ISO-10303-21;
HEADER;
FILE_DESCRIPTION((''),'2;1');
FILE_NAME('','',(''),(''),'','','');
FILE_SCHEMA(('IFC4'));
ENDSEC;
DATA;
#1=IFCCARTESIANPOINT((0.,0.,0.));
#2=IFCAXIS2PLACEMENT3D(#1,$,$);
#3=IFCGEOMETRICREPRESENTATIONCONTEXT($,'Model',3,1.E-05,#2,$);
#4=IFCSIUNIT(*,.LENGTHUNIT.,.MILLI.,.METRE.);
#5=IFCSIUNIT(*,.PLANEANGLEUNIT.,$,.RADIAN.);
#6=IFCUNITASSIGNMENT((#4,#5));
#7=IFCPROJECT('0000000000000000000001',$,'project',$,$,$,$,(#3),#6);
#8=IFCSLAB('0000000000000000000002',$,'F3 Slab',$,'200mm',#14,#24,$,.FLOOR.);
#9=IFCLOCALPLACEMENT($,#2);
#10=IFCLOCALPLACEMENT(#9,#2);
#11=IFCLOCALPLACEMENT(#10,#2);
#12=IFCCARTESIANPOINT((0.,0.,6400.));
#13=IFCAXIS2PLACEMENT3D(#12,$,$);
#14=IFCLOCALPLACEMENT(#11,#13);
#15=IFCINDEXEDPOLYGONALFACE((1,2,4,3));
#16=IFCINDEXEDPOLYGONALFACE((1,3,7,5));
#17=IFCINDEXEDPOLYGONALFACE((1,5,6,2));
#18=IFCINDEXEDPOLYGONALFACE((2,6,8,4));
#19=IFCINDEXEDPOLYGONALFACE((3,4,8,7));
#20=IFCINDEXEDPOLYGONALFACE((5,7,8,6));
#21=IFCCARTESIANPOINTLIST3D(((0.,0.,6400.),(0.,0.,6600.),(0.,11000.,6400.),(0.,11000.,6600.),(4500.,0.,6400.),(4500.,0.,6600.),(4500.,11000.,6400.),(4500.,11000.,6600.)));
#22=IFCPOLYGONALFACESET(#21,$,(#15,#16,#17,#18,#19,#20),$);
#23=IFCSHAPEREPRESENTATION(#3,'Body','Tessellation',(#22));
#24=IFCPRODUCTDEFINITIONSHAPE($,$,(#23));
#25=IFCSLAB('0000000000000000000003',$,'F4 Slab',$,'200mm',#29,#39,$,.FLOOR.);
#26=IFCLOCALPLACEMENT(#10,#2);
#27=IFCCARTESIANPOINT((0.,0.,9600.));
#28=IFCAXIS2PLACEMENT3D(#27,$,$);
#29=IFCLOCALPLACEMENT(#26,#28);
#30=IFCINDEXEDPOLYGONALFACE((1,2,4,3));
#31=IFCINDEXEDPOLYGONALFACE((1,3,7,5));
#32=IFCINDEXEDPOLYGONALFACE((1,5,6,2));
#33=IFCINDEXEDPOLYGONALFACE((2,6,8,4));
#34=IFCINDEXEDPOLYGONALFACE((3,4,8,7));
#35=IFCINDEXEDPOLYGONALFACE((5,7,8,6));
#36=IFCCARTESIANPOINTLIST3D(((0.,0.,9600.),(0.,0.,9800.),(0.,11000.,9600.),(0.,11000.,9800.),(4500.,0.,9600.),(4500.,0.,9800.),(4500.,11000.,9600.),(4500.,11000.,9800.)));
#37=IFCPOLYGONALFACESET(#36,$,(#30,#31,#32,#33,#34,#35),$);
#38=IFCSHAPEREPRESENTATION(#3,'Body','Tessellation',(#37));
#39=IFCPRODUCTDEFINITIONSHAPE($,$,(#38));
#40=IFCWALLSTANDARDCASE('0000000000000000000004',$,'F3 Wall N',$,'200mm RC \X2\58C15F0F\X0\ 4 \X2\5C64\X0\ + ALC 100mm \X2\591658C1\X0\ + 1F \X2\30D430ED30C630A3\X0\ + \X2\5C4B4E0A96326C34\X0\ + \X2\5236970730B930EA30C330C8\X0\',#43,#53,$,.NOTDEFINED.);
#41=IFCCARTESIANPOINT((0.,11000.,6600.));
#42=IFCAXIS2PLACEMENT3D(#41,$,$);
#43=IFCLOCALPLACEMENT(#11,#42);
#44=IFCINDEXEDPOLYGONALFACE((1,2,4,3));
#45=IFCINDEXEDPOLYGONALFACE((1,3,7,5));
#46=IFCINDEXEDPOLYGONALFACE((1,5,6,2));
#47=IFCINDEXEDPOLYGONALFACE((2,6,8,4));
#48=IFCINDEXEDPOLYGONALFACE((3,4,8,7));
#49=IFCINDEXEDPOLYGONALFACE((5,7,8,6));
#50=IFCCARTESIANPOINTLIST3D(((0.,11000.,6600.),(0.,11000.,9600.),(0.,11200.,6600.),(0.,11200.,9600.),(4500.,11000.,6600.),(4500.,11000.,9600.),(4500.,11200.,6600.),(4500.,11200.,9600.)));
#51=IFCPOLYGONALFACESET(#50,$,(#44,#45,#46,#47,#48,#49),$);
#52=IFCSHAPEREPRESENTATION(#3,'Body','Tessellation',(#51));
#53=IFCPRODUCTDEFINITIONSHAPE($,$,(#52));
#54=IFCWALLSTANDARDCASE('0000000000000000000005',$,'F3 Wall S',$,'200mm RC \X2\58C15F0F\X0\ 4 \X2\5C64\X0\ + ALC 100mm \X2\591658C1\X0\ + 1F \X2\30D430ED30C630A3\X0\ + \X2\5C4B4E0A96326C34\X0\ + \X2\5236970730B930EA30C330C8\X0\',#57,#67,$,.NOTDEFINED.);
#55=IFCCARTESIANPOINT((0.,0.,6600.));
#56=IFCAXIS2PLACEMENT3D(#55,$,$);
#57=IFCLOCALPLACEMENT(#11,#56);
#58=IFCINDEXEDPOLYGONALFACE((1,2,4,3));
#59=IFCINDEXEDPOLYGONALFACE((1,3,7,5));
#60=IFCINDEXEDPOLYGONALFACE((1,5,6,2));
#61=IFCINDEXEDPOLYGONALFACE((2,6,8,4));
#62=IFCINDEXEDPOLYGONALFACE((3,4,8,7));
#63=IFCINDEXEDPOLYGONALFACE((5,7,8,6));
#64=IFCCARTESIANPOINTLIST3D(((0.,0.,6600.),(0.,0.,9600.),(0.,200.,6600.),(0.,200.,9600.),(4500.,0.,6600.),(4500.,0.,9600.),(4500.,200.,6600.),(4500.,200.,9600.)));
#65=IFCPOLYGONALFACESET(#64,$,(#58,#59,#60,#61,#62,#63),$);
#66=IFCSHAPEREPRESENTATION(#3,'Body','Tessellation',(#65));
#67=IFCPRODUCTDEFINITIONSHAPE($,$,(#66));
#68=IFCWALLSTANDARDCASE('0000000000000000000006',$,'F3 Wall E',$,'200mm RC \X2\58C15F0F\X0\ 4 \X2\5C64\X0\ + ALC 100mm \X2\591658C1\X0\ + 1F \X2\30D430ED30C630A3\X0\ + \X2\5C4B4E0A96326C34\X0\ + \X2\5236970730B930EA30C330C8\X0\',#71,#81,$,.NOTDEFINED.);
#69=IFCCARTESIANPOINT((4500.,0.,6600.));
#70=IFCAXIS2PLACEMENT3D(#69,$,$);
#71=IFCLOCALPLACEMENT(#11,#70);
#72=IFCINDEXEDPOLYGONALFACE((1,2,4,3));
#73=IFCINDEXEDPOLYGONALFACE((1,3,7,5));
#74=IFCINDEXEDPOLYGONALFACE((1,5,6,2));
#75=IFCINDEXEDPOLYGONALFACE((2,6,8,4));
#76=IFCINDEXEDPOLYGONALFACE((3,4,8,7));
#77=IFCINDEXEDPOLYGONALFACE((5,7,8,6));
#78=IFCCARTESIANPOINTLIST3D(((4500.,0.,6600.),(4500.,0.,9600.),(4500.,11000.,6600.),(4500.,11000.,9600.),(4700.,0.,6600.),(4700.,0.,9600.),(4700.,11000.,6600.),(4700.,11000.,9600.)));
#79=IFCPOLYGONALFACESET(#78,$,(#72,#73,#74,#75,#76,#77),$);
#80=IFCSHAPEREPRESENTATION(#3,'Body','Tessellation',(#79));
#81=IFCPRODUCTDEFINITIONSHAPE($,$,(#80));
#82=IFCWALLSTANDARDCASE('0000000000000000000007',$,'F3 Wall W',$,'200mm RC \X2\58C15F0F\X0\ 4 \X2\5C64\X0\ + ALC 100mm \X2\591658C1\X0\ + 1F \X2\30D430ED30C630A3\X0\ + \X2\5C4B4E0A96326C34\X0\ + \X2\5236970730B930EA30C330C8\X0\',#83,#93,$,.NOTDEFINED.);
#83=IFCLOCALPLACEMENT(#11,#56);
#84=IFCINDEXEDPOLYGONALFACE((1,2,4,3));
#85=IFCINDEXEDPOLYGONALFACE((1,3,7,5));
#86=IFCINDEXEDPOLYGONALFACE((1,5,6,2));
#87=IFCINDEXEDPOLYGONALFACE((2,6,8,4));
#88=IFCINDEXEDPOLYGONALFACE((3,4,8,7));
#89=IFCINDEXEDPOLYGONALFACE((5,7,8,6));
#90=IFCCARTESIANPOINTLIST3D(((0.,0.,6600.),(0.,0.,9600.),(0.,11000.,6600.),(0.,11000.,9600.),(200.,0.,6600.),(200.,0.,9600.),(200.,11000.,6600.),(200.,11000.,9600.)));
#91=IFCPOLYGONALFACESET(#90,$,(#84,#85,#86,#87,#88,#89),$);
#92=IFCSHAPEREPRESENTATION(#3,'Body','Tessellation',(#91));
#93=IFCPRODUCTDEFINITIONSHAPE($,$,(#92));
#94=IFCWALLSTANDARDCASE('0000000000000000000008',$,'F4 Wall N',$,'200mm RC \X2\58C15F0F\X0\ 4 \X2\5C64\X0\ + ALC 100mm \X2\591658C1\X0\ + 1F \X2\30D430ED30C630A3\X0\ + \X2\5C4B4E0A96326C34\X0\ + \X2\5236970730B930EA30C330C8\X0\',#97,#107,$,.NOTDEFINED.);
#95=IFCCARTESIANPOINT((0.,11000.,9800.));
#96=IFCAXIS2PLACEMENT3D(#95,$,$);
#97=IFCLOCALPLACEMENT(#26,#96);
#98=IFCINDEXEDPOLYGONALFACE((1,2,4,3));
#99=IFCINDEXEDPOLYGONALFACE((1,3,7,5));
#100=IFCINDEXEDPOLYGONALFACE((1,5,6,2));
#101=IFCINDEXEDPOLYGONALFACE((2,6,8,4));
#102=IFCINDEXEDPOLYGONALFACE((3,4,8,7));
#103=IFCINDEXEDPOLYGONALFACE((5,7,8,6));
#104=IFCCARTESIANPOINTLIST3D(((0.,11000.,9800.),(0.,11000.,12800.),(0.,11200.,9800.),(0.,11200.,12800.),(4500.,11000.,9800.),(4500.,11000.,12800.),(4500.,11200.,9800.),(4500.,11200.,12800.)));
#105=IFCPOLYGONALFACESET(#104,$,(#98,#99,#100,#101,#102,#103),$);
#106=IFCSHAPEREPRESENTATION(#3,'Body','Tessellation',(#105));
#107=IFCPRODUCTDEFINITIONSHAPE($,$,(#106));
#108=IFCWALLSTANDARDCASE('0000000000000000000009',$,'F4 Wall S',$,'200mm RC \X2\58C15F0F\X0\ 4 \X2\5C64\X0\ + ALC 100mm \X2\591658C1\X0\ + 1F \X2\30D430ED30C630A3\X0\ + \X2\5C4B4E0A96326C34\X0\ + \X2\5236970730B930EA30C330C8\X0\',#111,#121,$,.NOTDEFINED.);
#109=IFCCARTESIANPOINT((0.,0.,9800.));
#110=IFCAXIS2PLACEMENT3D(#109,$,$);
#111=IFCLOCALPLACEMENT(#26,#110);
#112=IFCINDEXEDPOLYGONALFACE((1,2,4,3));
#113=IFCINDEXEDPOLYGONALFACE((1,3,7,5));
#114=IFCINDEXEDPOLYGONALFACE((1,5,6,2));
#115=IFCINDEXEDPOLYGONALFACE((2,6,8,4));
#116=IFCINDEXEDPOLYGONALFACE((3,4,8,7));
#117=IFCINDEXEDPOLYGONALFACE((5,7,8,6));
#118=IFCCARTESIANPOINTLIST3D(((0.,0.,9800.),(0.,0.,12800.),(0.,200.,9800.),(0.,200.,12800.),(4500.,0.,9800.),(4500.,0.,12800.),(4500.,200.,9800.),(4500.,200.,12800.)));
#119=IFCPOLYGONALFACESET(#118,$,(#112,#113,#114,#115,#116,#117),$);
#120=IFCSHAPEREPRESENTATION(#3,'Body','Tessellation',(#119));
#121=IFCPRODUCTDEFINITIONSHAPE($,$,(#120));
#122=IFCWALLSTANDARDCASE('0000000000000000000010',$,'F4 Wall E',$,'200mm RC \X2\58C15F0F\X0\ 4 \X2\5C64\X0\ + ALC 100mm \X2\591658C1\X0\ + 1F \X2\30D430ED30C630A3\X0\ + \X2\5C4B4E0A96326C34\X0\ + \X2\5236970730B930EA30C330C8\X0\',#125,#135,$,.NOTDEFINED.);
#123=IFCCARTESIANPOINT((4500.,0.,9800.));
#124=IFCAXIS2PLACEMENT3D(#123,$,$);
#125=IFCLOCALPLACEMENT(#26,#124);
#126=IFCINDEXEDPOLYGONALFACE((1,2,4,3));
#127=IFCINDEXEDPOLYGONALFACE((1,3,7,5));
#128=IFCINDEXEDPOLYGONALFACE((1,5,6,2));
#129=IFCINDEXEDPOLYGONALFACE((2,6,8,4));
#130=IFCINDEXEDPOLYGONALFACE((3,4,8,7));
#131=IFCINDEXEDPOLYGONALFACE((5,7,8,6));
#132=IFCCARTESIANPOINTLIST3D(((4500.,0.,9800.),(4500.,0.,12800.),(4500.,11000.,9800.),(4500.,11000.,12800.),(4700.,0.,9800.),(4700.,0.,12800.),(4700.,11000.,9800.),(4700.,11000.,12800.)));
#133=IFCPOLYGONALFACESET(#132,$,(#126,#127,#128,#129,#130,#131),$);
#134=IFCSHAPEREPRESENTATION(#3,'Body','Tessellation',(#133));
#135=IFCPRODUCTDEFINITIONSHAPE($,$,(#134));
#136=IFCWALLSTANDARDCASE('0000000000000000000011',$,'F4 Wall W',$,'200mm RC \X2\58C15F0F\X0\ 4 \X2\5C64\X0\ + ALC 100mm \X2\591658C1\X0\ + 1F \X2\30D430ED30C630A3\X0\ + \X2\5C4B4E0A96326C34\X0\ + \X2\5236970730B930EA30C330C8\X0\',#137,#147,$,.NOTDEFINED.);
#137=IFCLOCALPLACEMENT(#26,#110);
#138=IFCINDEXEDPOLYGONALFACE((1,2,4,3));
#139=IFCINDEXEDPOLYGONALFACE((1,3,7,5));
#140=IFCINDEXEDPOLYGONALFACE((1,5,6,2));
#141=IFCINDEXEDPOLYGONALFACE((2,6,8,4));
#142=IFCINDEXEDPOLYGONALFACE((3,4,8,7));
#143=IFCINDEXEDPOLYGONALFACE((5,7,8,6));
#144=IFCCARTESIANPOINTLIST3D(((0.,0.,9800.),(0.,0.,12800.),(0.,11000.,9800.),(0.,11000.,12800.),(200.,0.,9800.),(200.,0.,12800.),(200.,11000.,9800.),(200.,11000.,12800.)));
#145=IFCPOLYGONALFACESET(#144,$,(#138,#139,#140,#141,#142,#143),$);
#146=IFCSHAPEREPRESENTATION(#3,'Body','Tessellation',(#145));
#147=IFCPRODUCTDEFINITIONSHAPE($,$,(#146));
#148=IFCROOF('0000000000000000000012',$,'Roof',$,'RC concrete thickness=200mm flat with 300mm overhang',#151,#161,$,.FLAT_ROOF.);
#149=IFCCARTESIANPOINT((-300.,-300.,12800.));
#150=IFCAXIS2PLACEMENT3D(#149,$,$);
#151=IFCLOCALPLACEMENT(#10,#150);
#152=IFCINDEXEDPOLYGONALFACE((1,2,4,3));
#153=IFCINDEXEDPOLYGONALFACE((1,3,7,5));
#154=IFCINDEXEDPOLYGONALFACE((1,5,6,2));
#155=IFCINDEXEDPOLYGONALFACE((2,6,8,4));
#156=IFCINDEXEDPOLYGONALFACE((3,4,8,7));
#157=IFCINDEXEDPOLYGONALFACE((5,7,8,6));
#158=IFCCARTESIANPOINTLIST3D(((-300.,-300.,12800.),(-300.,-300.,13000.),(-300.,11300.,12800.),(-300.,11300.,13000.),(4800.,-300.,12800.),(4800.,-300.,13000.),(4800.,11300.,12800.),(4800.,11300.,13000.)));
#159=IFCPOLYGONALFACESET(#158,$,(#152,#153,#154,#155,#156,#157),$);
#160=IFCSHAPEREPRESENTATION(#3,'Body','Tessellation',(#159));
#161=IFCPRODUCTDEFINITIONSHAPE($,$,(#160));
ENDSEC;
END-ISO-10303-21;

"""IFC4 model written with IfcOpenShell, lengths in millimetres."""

from ifc_helpers import new_model, si_unit, frame, frame_2d, origin, place, context, project, rectangle, extrude, element, save


model = new_model("IFC4")

# Units and contexts
model_context = context("Model", 3, precision=1e-05, world=origin())
ifc_project = project(units=[si_unit("LENGTHUNIT", "METRE", prefix="MILLI"), si_unit("PLANEANGLEUNIT", "RADIAN")], contexts=[model_context])

# Slabs
placement_1 = place(None, origin())
placement_2 = place(placement_1, origin())
placement_3 = place(placement_2, origin())
slab_1_placement = place(placement_3, frame((0.0, 0.0, 6400.0)))
element("IfcSlab", 1, at=slab_1_placement, Name="F3 Slab", ObjectType="200mm", PredefinedType="FLOOR", context=model_context, shape_type="SweptSolid", body=[
    extrude(rectangle(XDim=4500.0, YDim=11000.0, at=frame_2d((2250.0, 5500.0))), frame((0.0, 0.0, 6400.0)), (0.0, 0.0, 1.0), 200.0),
])
placement_4 = place(placement_2, origin())
slab_2_placement = place(placement_4, frame((0.0, 0.0, 9600.0)))
element("IfcSlab", 2, at=slab_2_placement, Name="F4 Slab", ObjectType="200mm", PredefinedType="FLOOR", context=model_context, shape_type="SweptSolid", body=[
    extrude(rectangle(XDim=4500.0, YDim=11000.0, at=frame_2d((2250.0, 5500.0))), frame((0.0, 0.0, 9600.0)), (0.0, 0.0, 1.0), 200.0),
])

# Walls
wall_1_placement = place(placement_3, frame((0.0, 11000.0, 6600.0)))
element("IfcWallStandardCase", 3, at=wall_1_placement, Name="F3 Wall N", ObjectType="200mm RC 壁式 4 層 + ALC 100mm 外壁 + 1F ピロティ + 屋上防水 + 制震スリット", PredefinedType="NOTDEFINED", context=model_context, shape_type="SweptSolid", body=[
    extrude(rectangle(XDim=4500.0, YDim=200.0, at=frame_2d((2250.0, 100.0))), frame((0.0, 11000.0, 6600.0)), (0.0, 0.0, 1.0), 3000.0),
])
wall_2_placement = place(placement_3, frame((0.0, 0.0, 6600.0)))
element("IfcWallStandardCase", 4, at=wall_2_placement, Name="F3 Wall S", ObjectType="200mm RC 壁式 4 層 + ALC 100mm 外壁 + 1F ピロティ + 屋上防水 + 制震スリット", PredefinedType="NOTDEFINED", context=model_context, shape_type="SweptSolid", body=[
    extrude(rectangle(XDim=4500.0, YDim=200.0, at=frame_2d((2250.0, 100.0))), frame((0.0, 0.0, 6600.0)), (0.0, 0.0, 1.0), 3000.0),
])
wall_3_placement = place(placement_3, frame((4500.0, 0.0, 6600.0)))
element("IfcWallStandardCase", 5, at=wall_3_placement, Name="F3 Wall E", ObjectType="200mm RC 壁式 4 層 + ALC 100mm 外壁 + 1F ピロティ + 屋上防水 + 制震スリット", PredefinedType="NOTDEFINED", context=model_context, shape_type="SweptSolid", body=[
    extrude(rectangle(XDim=200.0, YDim=11000.0, at=frame_2d((100.0, 5500.0))), frame((4500.0, 0.0, 6600.0)), (0.0, 0.0, 1.0), 3000.0),
])
wall_4_placement = place(placement_3, frame((0.0, 0.0, 6600.0)))
element("IfcWallStandardCase", 6, at=wall_4_placement, Name="F3 Wall W", ObjectType="200mm RC 壁式 4 層 + ALC 100mm 外壁 + 1F ピロティ + 屋上防水 + 制震スリット", PredefinedType="NOTDEFINED", context=model_context, shape_type="SweptSolid", body=[
    extrude(rectangle(XDim=200.0, YDim=11000.0, at=frame_2d((100.0, 5500.0))), frame((0.0, 0.0, 6600.0)), (0.0, 0.0, 1.0), 3000.0),
])
wall_5_placement = place(placement_4, frame((0.0, 11000.0, 9800.0)))
element("IfcWallStandardCase", 7, at=wall_5_placement, Name="F4 Wall N", ObjectType="200mm RC 壁式 4 層 + ALC 100mm 外壁 + 1F ピロティ + 屋上防水 + 制震スリット", PredefinedType="NOTDEFINED", context=model_context, shape_type="SweptSolid", body=[
    extrude(rectangle(XDim=4500.0, YDim=200.0, at=frame_2d((2250.0, 100.0))), frame((0.0, 11000.0, 9800.0)), (0.0, 0.0, 1.0), 3000.0),
])
wall_6_placement = place(placement_4, frame((0.0, 0.0, 9800.0)))
element("IfcWallStandardCase", 8, at=wall_6_placement, Name="F4 Wall S", ObjectType="200mm RC 壁式 4 層 + ALC 100mm 外壁 + 1F ピロティ + 屋上防水 + 制震スリット", PredefinedType="NOTDEFINED", context=model_context, shape_type="SweptSolid", body=[
    extrude(rectangle(XDim=4500.0, YDim=200.0, at=frame_2d((2250.0, 100.0))), frame((0.0, 0.0, 9800.0)), (0.0, 0.0, 1.0), 3000.0),
])
wall_7_placement = place(placement_4, frame((4500.0, 0.0, 9800.0)))
element("IfcWallStandardCase", 9, at=wall_7_placement, Name="F4 Wall E", ObjectType="200mm RC 壁式 4 層 + ALC 100mm 外壁 + 1F ピロティ + 屋上防水 + 制震スリット", PredefinedType="NOTDEFINED", context=model_context, shape_type="SweptSolid", body=[
    extrude(rectangle(XDim=200.0, YDim=11000.0, at=frame_2d((100.0, 5500.0))), frame((4500.0, 0.0, 9800.0)), (0.0, 0.0, 1.0), 3000.0),
])
wall_8_placement = place(placement_4, frame((0.0, 0.0, 9800.0)))
element("IfcWallStandardCase", 10, at=wall_8_placement, Name="F4 Wall W", ObjectType="200mm RC 壁式 4 層 + ALC 100mm 外壁 + 1F ピロティ + 屋上防水 + 制震スリット", PredefinedType="NOTDEFINED", context=model_context, shape_type="SweptSolid", body=[
    extrude(rectangle(XDim=200.0, YDim=11000.0, at=frame_2d((100.0, 5500.0))), frame((0.0, 0.0, 9800.0)), (0.0, 0.0, 1.0), 3000.0),
])

# Roof
roof_placement = place(placement_2, frame((-300.0, -300.0, 12800.0)))
element("IfcRoof", 11, at=roof_placement, Name="Roof", ObjectType="RC concrete thickness=200mm flat with 300mm overhang", PredefinedType="FLAT_ROOF", context=model_context, shape_type="SweptSolid", body=[
    extrude(rectangle(XDim=5100.0, YDim=11600.0, at=frame_2d((2550.0, 5800.0))), frame((-300.0, -300.0, 12800.0)), (0.0, 0.0, 1.0), 200.0),
])

save(model, "model.ifc")
